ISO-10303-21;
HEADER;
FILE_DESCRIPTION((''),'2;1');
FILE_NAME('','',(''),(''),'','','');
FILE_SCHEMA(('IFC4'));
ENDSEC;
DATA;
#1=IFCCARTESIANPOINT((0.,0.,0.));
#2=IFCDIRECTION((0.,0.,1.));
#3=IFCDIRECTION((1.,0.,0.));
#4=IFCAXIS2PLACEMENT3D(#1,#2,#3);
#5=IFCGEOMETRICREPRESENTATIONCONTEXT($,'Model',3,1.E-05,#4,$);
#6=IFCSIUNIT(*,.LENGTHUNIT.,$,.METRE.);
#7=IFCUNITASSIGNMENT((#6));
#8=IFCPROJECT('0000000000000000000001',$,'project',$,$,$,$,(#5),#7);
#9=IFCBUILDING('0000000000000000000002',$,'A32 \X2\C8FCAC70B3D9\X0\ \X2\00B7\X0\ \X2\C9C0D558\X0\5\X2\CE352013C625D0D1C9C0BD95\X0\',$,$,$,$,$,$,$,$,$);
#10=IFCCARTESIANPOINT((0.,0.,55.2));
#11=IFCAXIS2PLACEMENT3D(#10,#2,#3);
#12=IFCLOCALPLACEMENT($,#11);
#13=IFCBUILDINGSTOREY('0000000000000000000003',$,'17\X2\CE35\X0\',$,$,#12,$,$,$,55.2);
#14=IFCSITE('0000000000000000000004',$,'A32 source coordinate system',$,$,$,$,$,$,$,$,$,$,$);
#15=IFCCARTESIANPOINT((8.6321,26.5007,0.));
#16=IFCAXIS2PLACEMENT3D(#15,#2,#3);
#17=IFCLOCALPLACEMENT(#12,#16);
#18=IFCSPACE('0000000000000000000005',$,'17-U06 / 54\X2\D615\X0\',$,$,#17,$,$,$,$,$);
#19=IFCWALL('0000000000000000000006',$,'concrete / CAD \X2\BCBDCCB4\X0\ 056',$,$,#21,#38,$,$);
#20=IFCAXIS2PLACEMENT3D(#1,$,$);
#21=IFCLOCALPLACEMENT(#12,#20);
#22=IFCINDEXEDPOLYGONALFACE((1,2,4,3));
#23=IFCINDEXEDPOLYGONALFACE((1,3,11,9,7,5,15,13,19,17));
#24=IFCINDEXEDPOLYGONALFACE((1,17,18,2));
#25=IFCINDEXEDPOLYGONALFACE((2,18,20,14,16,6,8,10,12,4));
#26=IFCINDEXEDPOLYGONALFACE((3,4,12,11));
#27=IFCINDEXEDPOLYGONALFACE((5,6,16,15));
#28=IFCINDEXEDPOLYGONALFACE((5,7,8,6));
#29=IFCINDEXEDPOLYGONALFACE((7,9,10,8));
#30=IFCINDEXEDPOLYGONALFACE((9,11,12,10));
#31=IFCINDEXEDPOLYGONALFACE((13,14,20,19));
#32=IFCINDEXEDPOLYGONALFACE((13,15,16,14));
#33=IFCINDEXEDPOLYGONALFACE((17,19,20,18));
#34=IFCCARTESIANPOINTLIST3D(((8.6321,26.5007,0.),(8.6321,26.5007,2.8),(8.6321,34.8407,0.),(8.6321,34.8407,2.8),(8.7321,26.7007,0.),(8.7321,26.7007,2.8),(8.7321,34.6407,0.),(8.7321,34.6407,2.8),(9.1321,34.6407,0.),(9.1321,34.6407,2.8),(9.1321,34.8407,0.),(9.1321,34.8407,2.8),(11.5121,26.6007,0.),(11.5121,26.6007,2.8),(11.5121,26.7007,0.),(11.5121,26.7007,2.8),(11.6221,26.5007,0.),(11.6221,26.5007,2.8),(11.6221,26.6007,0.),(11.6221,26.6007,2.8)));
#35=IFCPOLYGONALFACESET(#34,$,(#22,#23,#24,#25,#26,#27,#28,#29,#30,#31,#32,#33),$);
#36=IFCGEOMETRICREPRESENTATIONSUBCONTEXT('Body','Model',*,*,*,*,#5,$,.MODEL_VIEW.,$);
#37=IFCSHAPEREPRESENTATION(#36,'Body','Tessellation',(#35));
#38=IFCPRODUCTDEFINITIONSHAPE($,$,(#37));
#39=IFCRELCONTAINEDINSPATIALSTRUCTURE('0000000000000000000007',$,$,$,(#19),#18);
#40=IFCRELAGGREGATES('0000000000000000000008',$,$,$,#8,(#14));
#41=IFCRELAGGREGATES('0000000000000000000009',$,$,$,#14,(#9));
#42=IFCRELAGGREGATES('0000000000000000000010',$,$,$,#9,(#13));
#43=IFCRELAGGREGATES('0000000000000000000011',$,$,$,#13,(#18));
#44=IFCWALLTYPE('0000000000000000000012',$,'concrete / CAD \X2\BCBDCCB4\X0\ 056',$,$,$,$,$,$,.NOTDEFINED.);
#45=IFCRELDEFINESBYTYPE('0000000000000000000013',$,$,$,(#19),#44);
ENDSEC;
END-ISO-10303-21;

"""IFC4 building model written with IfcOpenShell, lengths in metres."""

from ifc_helpers import new_model, si_unit, frame, origin, origin_with_axes, place, context, subcontext, project, spatial, polyline, outline, extrude, source, transform, mapped, type_object, type_shapes, element, save


model = new_model("IFC4")

# Units and contexts
model_context = context("Model", 3, precision=1e-05, world=origin_with_axes())
body_context = subcontext(model_context, "Body", "Model", "MODEL_VIEW")
ifc_project = project(units=[si_unit("LENGTHUNIT", "METRE")], contexts=[model_context])

# Site, building, storey, space
site = spatial("IfcSite", under=ifc_project, Name="A32 source coordinate system")
building = spatial("IfcBuilding", under=site, Name="A32 주거동 · 지하5층–옥탑지붕")
storey_placement = place(None, frame((0.0, 0.0, 55.2), z_axis=(0.0, 0.0, 1.0), x_axis=(1.0, 0.0, 0.0)))
storey = spatial("IfcBuildingStorey", under=building, at=storey_placement, Name="17층", Elevation=55.2)
space_placement = place(storey_placement, frame((8.6321, 26.5007, 0.0), z_axis=(0.0, 0.0, 1.0), x_axis=(1.0, 0.0, 0.0)))
space = spatial("IfcSpace", under=storey, at=space_placement, Name="17-U06 / 54형")

# Wall
wall_type_1 = type_object("IfcWallType", Name="concrete / CAD 벽체 056", PredefinedType="NOTDEFINED")
shared_shape_1 = source(origin(), body_context, "Body", "SweptSolid", [
    extrude(outline(polyline([(0.1, 8.14), (0.1, 0.2), (2.88, 0.2), (2.88, 0.1), (2.99, 0.1), (2.99, 0.0), (0.0, 0.0), (0.0, 8.34), (-0.35, 8.34), (-0.35, 8.34), (0.5, 8.34), (0.5, 8.14), (0.1, 8.14)])), origin(), (0.0, 0.0, 1.0), 2.8),
])
type_shapes(wall_type_1, [shared_shape_1])
wall_1_placement = place(space_placement, origin_with_axes())
element("IfcWall", 1, at=wall_1_placement, inside=space, type_object=wall_type_1, Name="concrete / CAD 벽체 056", context=body_context, shape_type="MappedRepresentation", body=[
    mapped(shared_shape_1, transform((0.0, 0.0, 0.0), scale=1.0)),
])

save(model, "model.ifc")
